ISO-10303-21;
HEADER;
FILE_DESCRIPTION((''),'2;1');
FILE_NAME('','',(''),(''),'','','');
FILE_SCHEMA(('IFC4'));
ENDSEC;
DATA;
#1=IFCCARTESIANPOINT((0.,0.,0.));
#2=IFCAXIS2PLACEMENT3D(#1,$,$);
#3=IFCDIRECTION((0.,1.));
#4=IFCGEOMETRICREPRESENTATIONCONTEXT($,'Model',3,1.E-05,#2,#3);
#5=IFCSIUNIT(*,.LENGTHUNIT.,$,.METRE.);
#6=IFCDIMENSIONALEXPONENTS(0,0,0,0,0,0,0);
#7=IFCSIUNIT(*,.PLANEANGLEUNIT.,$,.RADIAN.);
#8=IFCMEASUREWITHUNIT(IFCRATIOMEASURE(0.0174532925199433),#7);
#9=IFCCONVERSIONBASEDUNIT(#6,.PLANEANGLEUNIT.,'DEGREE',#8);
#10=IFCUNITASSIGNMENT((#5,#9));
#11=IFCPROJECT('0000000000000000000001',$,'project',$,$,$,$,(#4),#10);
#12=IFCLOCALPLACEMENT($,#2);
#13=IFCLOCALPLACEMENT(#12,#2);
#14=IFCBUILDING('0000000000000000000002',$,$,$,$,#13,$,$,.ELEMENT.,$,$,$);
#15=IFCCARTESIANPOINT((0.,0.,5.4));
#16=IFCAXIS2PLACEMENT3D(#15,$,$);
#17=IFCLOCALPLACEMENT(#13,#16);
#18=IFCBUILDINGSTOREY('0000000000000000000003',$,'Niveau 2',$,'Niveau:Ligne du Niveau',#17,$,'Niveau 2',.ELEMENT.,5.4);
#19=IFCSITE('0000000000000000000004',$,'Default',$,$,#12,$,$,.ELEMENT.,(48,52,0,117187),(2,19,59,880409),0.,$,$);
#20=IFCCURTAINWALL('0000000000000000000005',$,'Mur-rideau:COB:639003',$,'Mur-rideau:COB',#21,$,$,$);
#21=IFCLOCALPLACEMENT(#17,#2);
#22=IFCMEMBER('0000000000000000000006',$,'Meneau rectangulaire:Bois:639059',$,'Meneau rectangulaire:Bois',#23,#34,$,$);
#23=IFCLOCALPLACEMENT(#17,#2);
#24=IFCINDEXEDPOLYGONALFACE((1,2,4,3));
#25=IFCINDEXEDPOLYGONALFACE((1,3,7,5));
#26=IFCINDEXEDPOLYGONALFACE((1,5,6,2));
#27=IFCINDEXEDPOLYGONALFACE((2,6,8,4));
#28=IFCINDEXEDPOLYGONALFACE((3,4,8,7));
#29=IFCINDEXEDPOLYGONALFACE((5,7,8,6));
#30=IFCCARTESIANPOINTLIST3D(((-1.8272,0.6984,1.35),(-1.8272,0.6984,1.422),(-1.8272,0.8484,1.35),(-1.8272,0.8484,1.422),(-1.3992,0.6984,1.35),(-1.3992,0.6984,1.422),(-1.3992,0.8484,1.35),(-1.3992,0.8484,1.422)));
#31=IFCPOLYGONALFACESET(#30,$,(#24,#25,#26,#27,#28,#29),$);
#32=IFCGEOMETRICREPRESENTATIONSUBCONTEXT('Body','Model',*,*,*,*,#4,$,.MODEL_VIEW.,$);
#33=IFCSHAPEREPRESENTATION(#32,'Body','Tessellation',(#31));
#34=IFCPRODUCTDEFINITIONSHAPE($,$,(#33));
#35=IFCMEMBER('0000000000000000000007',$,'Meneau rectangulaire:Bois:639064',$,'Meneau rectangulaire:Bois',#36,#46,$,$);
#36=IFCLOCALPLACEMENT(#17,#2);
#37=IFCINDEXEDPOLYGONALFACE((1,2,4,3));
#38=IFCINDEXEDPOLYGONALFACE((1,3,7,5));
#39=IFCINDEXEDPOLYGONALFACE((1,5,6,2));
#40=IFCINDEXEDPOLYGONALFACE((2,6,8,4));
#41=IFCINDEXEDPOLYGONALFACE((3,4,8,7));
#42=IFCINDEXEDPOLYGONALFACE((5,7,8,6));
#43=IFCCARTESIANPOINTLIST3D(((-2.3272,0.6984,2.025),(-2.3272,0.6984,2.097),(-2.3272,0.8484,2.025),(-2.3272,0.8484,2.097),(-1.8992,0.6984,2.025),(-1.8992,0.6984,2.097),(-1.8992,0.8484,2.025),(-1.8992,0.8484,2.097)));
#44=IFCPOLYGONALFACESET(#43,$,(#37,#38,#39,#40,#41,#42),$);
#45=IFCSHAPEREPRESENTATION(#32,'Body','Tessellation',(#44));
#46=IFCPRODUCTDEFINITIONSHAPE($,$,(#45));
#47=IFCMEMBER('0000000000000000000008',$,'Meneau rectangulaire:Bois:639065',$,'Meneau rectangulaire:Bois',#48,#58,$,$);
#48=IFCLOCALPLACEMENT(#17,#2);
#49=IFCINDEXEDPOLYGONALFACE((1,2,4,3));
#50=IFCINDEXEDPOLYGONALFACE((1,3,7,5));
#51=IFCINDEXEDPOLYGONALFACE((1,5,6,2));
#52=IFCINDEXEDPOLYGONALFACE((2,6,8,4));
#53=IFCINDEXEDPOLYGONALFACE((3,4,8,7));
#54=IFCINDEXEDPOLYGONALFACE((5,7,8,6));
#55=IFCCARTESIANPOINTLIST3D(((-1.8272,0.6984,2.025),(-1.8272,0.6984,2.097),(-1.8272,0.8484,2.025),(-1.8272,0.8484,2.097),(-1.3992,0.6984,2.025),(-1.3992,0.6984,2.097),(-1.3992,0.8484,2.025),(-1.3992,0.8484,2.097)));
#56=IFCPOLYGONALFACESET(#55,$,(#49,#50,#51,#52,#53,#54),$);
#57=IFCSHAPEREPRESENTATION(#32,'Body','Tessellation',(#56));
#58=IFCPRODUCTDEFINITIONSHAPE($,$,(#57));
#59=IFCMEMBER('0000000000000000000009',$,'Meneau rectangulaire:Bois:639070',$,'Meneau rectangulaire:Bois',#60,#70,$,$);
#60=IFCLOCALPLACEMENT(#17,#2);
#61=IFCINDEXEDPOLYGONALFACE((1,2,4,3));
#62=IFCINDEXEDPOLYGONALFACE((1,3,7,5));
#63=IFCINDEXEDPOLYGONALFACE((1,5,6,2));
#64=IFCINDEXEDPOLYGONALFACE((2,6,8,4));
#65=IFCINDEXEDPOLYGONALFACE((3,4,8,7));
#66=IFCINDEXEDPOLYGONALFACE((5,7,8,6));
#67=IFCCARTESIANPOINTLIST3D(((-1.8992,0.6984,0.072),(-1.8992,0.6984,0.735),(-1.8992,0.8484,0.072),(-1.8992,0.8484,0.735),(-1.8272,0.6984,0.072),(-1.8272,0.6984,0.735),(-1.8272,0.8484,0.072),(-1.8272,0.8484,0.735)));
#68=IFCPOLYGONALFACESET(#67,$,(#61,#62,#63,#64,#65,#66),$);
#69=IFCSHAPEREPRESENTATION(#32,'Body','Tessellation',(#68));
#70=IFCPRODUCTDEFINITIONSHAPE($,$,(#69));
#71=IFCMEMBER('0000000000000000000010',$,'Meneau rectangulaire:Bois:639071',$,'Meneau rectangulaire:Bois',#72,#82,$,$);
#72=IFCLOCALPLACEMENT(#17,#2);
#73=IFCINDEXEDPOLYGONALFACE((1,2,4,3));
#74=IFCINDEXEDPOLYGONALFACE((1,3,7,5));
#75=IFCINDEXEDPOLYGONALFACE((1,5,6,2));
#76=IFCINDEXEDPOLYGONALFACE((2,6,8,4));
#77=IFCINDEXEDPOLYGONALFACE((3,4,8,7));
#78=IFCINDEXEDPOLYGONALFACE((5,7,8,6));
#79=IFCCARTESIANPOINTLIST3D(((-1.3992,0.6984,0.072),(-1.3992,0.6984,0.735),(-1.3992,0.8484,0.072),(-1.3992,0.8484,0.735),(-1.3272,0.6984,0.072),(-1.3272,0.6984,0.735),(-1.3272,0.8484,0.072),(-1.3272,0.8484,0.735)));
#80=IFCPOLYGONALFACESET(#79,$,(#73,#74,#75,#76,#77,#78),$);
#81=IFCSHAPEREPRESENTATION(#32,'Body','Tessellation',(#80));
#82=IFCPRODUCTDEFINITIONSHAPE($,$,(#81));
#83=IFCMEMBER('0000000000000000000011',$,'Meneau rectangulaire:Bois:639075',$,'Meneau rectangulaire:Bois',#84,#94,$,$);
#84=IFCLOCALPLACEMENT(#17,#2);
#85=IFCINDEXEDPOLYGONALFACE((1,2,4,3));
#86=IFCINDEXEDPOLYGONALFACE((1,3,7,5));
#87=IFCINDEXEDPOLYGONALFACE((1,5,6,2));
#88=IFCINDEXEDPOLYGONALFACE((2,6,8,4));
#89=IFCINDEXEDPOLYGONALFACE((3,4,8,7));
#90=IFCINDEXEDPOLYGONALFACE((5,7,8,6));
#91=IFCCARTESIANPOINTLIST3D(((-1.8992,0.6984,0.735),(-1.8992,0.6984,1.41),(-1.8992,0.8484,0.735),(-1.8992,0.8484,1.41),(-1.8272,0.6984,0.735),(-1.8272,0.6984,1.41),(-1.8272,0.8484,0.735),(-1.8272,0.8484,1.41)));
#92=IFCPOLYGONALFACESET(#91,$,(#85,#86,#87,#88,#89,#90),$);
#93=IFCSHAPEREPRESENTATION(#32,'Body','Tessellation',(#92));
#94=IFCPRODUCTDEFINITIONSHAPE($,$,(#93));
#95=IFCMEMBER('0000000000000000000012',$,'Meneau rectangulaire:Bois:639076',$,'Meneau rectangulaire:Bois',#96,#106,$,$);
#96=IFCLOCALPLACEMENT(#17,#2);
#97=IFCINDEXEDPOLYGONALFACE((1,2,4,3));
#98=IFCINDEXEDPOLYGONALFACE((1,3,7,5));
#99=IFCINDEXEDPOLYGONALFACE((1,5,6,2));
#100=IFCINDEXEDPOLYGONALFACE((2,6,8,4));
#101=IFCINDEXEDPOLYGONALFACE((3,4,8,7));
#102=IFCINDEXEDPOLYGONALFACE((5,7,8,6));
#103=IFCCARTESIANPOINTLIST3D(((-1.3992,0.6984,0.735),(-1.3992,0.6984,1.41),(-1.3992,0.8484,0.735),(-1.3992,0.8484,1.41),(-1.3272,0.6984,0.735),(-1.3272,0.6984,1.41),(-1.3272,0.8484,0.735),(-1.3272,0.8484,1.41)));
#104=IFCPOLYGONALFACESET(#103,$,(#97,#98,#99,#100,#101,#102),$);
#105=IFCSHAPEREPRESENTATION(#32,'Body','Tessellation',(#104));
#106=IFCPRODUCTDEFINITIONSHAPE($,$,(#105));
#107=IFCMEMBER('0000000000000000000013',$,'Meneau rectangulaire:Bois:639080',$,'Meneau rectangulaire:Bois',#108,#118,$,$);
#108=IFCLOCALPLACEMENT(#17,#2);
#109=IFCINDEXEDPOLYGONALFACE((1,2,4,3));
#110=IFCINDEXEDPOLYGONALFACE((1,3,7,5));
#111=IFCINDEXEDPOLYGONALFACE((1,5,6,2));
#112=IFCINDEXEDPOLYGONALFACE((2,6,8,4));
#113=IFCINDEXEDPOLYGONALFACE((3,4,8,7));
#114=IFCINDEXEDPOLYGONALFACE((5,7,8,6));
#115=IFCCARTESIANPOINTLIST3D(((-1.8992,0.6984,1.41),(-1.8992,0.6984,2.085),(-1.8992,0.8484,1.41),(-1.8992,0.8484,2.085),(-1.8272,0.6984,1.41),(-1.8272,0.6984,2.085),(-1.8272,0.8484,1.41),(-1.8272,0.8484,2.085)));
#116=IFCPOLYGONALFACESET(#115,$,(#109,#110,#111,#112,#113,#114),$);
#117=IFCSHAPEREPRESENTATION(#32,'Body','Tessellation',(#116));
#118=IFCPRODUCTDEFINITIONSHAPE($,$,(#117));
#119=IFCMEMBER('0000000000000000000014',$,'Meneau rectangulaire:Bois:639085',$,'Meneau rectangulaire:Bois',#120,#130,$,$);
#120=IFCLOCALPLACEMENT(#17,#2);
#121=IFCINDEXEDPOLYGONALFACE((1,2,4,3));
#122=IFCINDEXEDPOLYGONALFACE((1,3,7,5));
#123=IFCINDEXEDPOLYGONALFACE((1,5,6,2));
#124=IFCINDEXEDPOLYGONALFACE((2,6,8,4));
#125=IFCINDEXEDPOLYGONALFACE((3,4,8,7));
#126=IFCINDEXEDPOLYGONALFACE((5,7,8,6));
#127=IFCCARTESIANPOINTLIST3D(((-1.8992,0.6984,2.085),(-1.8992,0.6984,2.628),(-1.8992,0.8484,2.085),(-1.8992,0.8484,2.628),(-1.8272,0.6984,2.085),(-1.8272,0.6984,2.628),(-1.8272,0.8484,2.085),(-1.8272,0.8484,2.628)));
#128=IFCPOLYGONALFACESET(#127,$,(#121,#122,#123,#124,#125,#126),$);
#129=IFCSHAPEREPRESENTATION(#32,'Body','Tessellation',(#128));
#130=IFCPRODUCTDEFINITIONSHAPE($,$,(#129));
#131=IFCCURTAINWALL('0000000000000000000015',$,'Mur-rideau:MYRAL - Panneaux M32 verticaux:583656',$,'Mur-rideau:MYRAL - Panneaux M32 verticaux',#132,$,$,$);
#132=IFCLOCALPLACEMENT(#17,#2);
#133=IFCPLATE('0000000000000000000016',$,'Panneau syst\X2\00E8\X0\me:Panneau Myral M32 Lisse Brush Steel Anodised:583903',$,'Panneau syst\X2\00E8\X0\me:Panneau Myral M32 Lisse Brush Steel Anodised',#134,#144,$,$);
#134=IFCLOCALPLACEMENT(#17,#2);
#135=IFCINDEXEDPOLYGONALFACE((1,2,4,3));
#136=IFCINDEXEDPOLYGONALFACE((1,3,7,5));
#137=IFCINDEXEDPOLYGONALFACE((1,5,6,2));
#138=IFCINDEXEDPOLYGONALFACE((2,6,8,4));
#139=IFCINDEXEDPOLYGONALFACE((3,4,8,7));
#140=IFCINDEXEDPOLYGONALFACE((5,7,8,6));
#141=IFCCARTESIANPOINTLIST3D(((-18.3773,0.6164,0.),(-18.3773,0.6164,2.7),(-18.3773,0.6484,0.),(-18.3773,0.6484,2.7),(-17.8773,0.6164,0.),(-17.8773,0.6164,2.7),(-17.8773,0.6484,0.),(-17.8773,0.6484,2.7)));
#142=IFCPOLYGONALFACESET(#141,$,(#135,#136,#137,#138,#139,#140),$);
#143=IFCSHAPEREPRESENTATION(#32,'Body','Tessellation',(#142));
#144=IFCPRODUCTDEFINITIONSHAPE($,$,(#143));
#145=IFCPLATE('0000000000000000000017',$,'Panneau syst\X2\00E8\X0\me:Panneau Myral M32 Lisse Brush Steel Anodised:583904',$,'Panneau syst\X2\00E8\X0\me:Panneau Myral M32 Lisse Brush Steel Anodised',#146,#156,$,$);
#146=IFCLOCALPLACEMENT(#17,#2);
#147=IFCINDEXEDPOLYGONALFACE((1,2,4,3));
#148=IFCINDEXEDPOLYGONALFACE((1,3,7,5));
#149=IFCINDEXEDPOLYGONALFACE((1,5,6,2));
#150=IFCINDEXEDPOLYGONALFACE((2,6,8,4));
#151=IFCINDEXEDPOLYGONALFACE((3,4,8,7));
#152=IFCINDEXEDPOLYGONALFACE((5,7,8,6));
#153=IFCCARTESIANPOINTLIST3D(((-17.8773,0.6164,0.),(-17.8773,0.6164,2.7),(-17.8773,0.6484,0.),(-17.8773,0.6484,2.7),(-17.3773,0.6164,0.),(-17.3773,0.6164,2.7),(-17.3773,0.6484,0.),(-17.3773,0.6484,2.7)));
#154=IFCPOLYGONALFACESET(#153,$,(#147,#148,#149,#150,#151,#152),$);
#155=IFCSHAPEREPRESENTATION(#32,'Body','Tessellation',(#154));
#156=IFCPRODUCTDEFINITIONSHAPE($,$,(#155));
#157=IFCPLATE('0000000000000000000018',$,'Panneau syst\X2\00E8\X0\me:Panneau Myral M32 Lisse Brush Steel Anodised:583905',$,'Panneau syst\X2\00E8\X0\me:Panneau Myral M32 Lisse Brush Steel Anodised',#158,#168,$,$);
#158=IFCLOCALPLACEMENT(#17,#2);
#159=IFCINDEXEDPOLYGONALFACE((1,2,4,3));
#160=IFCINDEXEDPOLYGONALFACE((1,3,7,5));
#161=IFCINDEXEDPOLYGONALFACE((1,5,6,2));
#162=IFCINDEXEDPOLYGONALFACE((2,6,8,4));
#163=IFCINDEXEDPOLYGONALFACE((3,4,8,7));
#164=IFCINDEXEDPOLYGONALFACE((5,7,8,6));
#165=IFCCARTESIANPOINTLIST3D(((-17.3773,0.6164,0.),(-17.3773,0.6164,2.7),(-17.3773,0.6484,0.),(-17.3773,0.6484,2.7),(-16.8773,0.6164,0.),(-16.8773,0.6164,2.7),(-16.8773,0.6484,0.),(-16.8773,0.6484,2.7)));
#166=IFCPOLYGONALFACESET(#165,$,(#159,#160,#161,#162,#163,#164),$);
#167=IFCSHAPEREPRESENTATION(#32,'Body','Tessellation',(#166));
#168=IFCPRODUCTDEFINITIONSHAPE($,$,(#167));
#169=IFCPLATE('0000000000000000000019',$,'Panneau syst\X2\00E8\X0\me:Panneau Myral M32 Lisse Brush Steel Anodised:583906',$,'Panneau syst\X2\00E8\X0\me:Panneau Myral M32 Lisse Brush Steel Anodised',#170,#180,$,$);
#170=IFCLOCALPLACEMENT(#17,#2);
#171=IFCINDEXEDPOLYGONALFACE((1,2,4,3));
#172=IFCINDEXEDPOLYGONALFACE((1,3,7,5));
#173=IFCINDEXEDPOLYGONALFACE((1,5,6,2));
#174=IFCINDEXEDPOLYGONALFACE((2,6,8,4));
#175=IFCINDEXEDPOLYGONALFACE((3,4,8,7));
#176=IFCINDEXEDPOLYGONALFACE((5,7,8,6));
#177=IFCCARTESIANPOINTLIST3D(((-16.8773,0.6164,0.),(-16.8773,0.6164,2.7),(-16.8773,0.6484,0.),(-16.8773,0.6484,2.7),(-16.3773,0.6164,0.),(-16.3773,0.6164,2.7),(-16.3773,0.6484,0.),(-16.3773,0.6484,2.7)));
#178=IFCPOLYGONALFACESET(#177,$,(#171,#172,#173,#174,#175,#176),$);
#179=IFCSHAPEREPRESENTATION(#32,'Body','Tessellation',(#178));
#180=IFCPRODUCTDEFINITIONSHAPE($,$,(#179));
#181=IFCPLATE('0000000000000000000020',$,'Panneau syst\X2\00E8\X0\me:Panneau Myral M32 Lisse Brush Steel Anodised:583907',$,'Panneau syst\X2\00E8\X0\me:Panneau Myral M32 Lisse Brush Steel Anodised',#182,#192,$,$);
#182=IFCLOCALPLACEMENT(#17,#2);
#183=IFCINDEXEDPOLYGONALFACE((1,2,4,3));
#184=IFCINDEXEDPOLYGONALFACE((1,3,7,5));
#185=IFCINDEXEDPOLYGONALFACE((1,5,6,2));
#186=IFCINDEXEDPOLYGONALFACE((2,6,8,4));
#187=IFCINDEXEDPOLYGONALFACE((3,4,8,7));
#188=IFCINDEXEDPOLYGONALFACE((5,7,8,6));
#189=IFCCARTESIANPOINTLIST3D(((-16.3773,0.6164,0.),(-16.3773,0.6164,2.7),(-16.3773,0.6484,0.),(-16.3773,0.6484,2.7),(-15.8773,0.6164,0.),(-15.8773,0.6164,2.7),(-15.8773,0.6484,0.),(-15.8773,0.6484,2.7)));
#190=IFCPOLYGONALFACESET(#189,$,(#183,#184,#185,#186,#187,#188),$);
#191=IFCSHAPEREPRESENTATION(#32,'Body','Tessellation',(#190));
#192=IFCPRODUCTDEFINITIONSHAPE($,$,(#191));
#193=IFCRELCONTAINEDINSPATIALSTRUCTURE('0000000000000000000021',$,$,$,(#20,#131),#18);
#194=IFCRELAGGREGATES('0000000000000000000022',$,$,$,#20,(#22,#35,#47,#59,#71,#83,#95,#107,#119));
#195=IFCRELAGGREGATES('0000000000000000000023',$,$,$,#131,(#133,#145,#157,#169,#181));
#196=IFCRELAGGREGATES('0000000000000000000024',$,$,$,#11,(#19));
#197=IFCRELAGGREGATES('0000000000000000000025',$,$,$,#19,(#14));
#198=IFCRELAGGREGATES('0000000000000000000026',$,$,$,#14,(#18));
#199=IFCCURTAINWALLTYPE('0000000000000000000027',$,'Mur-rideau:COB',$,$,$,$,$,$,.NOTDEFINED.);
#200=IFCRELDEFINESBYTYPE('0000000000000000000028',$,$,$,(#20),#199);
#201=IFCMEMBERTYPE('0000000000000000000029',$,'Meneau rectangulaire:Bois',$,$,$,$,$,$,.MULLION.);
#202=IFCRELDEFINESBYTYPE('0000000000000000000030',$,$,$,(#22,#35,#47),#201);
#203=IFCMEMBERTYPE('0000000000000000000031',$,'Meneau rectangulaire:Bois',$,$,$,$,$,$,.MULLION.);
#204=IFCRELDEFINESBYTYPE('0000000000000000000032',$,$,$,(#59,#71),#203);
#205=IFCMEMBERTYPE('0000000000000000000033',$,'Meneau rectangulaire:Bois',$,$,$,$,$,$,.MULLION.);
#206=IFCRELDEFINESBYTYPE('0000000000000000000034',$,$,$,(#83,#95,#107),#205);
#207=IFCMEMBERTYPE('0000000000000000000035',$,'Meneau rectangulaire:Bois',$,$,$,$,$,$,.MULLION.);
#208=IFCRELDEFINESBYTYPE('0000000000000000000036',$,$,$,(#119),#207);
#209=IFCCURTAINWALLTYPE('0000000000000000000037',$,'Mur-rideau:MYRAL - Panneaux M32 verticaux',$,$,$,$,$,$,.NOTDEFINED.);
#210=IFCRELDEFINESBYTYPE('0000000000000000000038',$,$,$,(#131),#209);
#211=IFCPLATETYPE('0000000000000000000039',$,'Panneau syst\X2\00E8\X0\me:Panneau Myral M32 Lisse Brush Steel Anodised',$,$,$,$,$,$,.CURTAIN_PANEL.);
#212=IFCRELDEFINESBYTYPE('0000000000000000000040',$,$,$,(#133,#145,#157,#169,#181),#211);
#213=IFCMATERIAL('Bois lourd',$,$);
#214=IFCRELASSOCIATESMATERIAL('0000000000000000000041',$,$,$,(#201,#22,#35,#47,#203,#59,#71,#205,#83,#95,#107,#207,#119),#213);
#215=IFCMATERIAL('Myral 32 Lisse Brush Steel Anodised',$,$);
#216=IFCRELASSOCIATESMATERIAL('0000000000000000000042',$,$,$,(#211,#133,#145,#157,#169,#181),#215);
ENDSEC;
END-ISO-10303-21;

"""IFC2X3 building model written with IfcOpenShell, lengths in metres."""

from ifc_helpers import new_model, entity, si_unit, converted_unit, direction, frame, origin, origin_2d_with_axis, place, context, subcontext, project, spatial, rectangle, extrude, source, transform, mapped, material, type_object, type_shapes, element, aggregate, save


model = new_model("IFC2X3")

# Units and contexts
model_context = context("Model", 3, precision=1e-05, world=origin(), true_north=direction((0.0, 1.0)))
body_context = subcontext(model_context, "Body", "Model", "MODEL_VIEW")
ifc_project = project(units=[si_unit("LENGTHUNIT", "METRE"), converted_unit("PLANEANGLEUNIT", "DEGREE", entity("IfcRatioMeasure", 0.0174532925199433), si_unit("PLANEANGLEUNIT", "RADIAN"), dimensions=[0, 0, 0, 0, 0, 0, 0])], contexts=[model_context])

# Site, building, storey
site_placement = place(None, origin())
site = spatial("IfcSite", under=ifc_project, at=site_placement, Name="Default", CompositionType="ELEMENT", RefLatitude=(48, 52, 0, 117187), RefLongitude=(2, 19, 59, 880409), RefElevation=0.0)
building_placement = place(site_placement, origin())
building = spatial("IfcBuilding", under=site, at=building_placement, CompositionType="ELEMENT")
storey_placement = place(building_placement, frame((0.0, 0.0, 5.4)))
storey = spatial("IfcBuildingStorey", under=building, at=storey_placement, Name="Niveau 2", ObjectType="Niveau:Ligne du Niveau", LongName="Niveau 2", CompositionType="ELEMENT", Elevation=5.4)

# Curtain wall, members
curtain_wall_type_1 = type_object("IfcCurtainWallType", Name="Mur-rideau:COB", PredefinedType="NOTDEFINED")
curtain_wall_1_placement = place(storey_placement, frame((0.0, 0.0, -5.4)))
curtain_wall_1 = element("IfcCurtainWall", 1, at=curtain_wall_1_placement, inside=storey, type_object=curtain_wall_type_1, Name="Mur-rideau:COB:639003", ObjectType="Mur-rideau:COB")
ifc_material_1 = material(Name="Bois lourd")
member_type_1 = type_object("IfcMemberType", Name="Meneau rectangulaire:Bois", PredefinedType="MULLION", material=ifc_material_1)
shared_shape_1 = source(origin(), body_context, "Body", "SweptSolid", [
    extrude(rectangle(XDim=0.15, YDim=0.072, at=origin_2d_with_axis()), frame((-0.024, 0.0, -0.428), z_axis=(0.0, 0.0, 1.0), x_axis=(0.0, -1.0, 0.0)), (0.0, 0.0, 1.0), 0.428),
])
type_shapes(member_type_1, [shared_shape_1])
member_1_placement = place(storey_placement, frame((-1.3992, 0.7734, 1.41), z_axis=(1.0, 0.0, 0.0), x_axis=(0.0, 0.0, 1.0)))
member_1 = element("IfcMember", 2, at=member_1_placement, type_object=member_type_1, material=ifc_material_1, Name="Meneau rectangulaire:Bois:639059", ObjectType="Meneau rectangulaire:Bois", context=body_context, shape_type="MappedRepresentation", body=[
    mapped(shared_shape_1, transform((0.0, 0.0, 0.0), scale=1.0)),
])
member_2_placement = place(storey_placement, frame((-1.8992, 0.7734, 2.085), z_axis=(1.0, 0.0, 0.0), x_axis=(0.0, 0.0, 1.0)))
member_2 = element("IfcMember", 3, at=member_2_placement, type_object=member_type_1, material=ifc_material_1, Name="Meneau rectangulaire:Bois:639064", ObjectType="Meneau rectangulaire:Bois", context=body_context, shape_type="MappedRepresentation", body=[
    mapped(shared_shape_1, transform((0.0, 0.0, 0.0), scale=1.0)),
])
member_3_placement = place(storey_placement, frame((-1.3992, 0.7734, 2.085), z_axis=(1.0, 0.0, 0.0), x_axis=(0.0, 0.0, 1.0)))
member_3 = element("IfcMember", 4, at=member_3_placement, type_object=member_type_1, material=ifc_material_1, Name="Meneau rectangulaire:Bois:639065", ObjectType="Meneau rectangulaire:Bois", context=body_context, shape_type="MappedRepresentation", body=[
    mapped(shared_shape_1, transform((0.0, 0.0, 0.0), scale=1.0)),
])
member_type_2 = type_object("IfcMemberType", Name="Meneau rectangulaire:Bois", PredefinedType="MULLION", material=ifc_material_1)
shared_shape_2 = source(origin(), body_context, "Body", "SweptSolid", [
    extrude(rectangle(XDim=0.15, YDim=0.072, at=origin_2d_with_axis()), frame((-0.024, 0.0, -0.663), z_axis=(0.0, 0.0, 1.0), x_axis=(0.0, -1.0, 0.0)), (0.0, 0.0, 1.0), 0.663),
])
type_shapes(member_type_2, [shared_shape_2])
member_4_placement = place(storey_placement, frame((-1.8392, 0.7734, 0.072), z_axis=(0.0, 0.0, -1.0), x_axis=(1.0, 0.0, 0.0)))
member_4 = element("IfcMember", 5, at=member_4_placement, type_object=member_type_2, material=ifc_material_1, Name="Meneau rectangulaire:Bois:639070", ObjectType="Meneau rectangulaire:Bois", context=body_context, shape_type="MappedRepresentation", body=[
    mapped(shared_shape_2, transform((0.0, 0.0, 0.0), scale=1.0)),
])
member_5_placement = place(storey_placement, frame((-1.3392, 0.7734, 0.072), z_axis=(0.0, 0.0, -1.0), x_axis=(1.0, 0.0, 0.0)))
member_5 = element("IfcMember", 6, at=member_5_placement, type_object=member_type_2, material=ifc_material_1, Name="Meneau rectangulaire:Bois:639071", ObjectType="Meneau rectangulaire:Bois", context=body_context, shape_type="MappedRepresentation", body=[
    mapped(shared_shape_2, transform((0.0, 0.0, 0.0), scale=1.0)),
])
member_type_3 = type_object("IfcMemberType", Name="Meneau rectangulaire:Bois", PredefinedType="MULLION", material=ifc_material_1)
shared_shape_3 = source(origin(), body_context, "Body", "SweptSolid", [
    extrude(rectangle(XDim=0.15, YDim=0.072, at=origin_2d_with_axis()), frame((-0.024, 0.0, -0.675), z_axis=(0.0, 0.0, 1.0), x_axis=(0.0, -1.0, 0.0)), (0.0, 0.0, 1.0), 0.675),
])
type_shapes(member_type_3, [shared_shape_3])
member_6_placement = place(storey_placement, frame((-1.8392, 0.7734, 0.735), z_axis=(0.0, 0.0, -1.0), x_axis=(1.0, 0.0, 0.0)))
member_6 = element("IfcMember", 7, at=member_6_placement, type_object=member_type_3, material=ifc_material_1, Name="Meneau rectangulaire:Bois:639075", ObjectType="Meneau rectangulaire:Bois", context=body_context, shape_type="MappedRepresentation", body=[
    mapped(shared_shape_3, transform((0.0, 0.0, 0.0), scale=1.0)),
])
member_7_placement = place(storey_placement, frame((-1.3392, 0.7734, 0.735), z_axis=(0.0, 0.0, -1.0), x_axis=(1.0, 0.0, 0.0)))
member_7 = element("IfcMember", 8, at=member_7_placement, type_object=member_type_3, material=ifc_material_1, Name="Meneau rectangulaire:Bois:639076", ObjectType="Meneau rectangulaire:Bois", context=body_context, shape_type="MappedRepresentation", body=[
    mapped(shared_shape_3, transform((0.0, 0.0, 0.0), scale=1.0)),
])
member_8_placement = place(storey_placement, frame((-1.8392, 0.7734, 1.41), z_axis=(0.0, 0.0, -1.0), x_axis=(1.0, 0.0, 0.0)))
member_8 = element("IfcMember", 9, at=member_8_placement, type_object=member_type_3, material=ifc_material_1, Name="Meneau rectangulaire:Bois:639080", ObjectType="Meneau rectangulaire:Bois", context=body_context, shape_type="MappedRepresentation", body=[
    mapped(shared_shape_3, transform((0.0, 0.0, 0.0), scale=1.0)),
])
member_type_4 = type_object("IfcMemberType", Name="Meneau rectangulaire:Bois", PredefinedType="MULLION", material=ifc_material_1)
shared_shape_4 = source(origin(), body_context, "Body", "SweptSolid", [
    extrude(rectangle(XDim=0.15, YDim=0.072, at=origin_2d_with_axis()), frame((-0.024, 0.0, -0.543), z_axis=(0.0, 0.0, 1.0), x_axis=(0.0, -1.0, 0.0)), (0.0, 0.0, 1.0), 0.543),
])
type_shapes(member_type_4, [shared_shape_4])
member_9_placement = place(storey_placement, frame((-1.8392, 0.7734, 2.085), z_axis=(0.0, 0.0, -1.0), x_axis=(1.0, 0.0, 0.0)))
member_9 = element("IfcMember", 10, at=member_9_placement, type_object=member_type_4, material=ifc_material_1, Name="Meneau rectangulaire:Bois:639085", ObjectType="Meneau rectangulaire:Bois", context=body_context, shape_type="MappedRepresentation", body=[
    mapped(shared_shape_4, transform((0.0, 0.0, 0.0), scale=1.0)),
])
aggregate(curtain_wall_1, [member_1, member_2, member_3, member_4, member_5, member_6, member_7, member_8, member_9])

# Curtain wall, plates
curtain_wall_type_2 = type_object("IfcCurtainWallType", Name="Mur-rideau:MYRAL - Panneaux M32 verticaux", PredefinedType="NOTDEFINED")
curtain_wall_2_placement = place(storey_placement, frame((0.0, 0.0, -5.4)))
curtain_wall_2 = element("IfcCurtainWall", 11, at=curtain_wall_2_placement, inside=storey, type_object=curtain_wall_type_2, Name="Mur-rideau:MYRAL - Panneaux M32 verticaux:583656", ObjectType="Mur-rideau:MYRAL - Panneaux M32 verticaux")
ifc_material_2 = material(Name="Myral 32 Lisse Brush Steel Anodised")
plate_type = type_object("IfcPlateType", Name="Panneau système:Panneau Myral M32 Lisse Brush Steel Anodised", PredefinedType="CURTAIN_PANEL", material=ifc_material_2)
shared_shape_5 = source(origin(), body_context, "Body", "SweptSolid", [
    extrude(rectangle(XDim=0.032, YDim=0.5, at=origin_2d_with_axis()), frame((0.0, -0.016, 0.0), z_axis=(0.0, 0.0, 1.0), x_axis=(0.0, 1.0, 0.0)), (0.0, 0.0, 1.0), 2.7),
])
type_shapes(plate_type, [shared_shape_5])
plate_1_placement = place(curtain_wall_2_placement, frame((-18.1273, 0.6484, 5.4)))
plate_1 = element("IfcPlate", 12, at=plate_1_placement, type_object=plate_type, material=ifc_material_2, Name="Panneau système:Panneau Myral M32 Lisse Brush Steel Anodised:583903", ObjectType="Panneau système:Panneau Myral M32 Lisse Brush Steel Anodised", context=body_context, shape_type="MappedRepresentation", body=[
    mapped(shared_shape_5, transform((0.0, 0.0, 0.0), scale=1.0)),
])
plate_2_placement = place(curtain_wall_2_placement, frame((-17.6273, 0.6484, 5.4)))
plate_2 = element("IfcPlate", 13, at=plate_2_placement, type_object=plate_type, material=ifc_material_2, Name="Panneau système:Panneau Myral M32 Lisse Brush Steel Anodised:583904", ObjectType="Panneau système:Panneau Myral M32 Lisse Brush Steel Anodised", context=body_context, shape_type="MappedRepresentation", body=[
    mapped(shared_shape_5, transform((0.0, 0.0, 0.0), scale=1.0)),
])
plate_3_placement = place(curtain_wall_2_placement, frame((-17.1273, 0.6484, 5.4)))
plate_3 = element("IfcPlate", 14, at=plate_3_placement, type_object=plate_type, material=ifc_material_2, Name="Panneau système:Panneau Myral M32 Lisse Brush Steel Anodised:583905", ObjectType="Panneau système:Panneau Myral M32 Lisse Brush Steel Anodised", context=body_context, shape_type="MappedRepresentation", body=[
    mapped(shared_shape_5, transform((0.0, 0.0, 0.0), scale=1.0)),
])
plate_4_placement = place(curtain_wall_2_placement, frame((-16.6273, 0.6484, 5.4)))
plate_4 = element("IfcPlate", 15, at=plate_4_placement, type_object=plate_type, material=ifc_material_2, Name="Panneau système:Panneau Myral M32 Lisse Brush Steel Anodised:583906", ObjectType="Panneau système:Panneau Myral M32 Lisse Brush Steel Anodised", context=body_context, shape_type="MappedRepresentation", body=[
    mapped(shared_shape_5, transform((0.0, 0.0, 0.0), scale=1.0)),
])
plate_5_placement = place(curtain_wall_2_placement, frame((-16.1273, 0.6484, 5.4)))
plate_5 = element("IfcPlate", 16, at=plate_5_placement, type_object=plate_type, material=ifc_material_2, Name="Panneau système:Panneau Myral M32 Lisse Brush Steel Anodised:583907", ObjectType="Panneau système:Panneau Myral M32 Lisse Brush Steel Anodised", context=body_context, shape_type="MappedRepresentation", body=[
    mapped(shared_shape_5, transform((0.0, 0.0, 0.0), scale=1.0)),
])
aggregate(curtain_wall_2, [plate_1, plate_2, plate_3, plate_4, plate_5])

save(model, "model.ifc")
